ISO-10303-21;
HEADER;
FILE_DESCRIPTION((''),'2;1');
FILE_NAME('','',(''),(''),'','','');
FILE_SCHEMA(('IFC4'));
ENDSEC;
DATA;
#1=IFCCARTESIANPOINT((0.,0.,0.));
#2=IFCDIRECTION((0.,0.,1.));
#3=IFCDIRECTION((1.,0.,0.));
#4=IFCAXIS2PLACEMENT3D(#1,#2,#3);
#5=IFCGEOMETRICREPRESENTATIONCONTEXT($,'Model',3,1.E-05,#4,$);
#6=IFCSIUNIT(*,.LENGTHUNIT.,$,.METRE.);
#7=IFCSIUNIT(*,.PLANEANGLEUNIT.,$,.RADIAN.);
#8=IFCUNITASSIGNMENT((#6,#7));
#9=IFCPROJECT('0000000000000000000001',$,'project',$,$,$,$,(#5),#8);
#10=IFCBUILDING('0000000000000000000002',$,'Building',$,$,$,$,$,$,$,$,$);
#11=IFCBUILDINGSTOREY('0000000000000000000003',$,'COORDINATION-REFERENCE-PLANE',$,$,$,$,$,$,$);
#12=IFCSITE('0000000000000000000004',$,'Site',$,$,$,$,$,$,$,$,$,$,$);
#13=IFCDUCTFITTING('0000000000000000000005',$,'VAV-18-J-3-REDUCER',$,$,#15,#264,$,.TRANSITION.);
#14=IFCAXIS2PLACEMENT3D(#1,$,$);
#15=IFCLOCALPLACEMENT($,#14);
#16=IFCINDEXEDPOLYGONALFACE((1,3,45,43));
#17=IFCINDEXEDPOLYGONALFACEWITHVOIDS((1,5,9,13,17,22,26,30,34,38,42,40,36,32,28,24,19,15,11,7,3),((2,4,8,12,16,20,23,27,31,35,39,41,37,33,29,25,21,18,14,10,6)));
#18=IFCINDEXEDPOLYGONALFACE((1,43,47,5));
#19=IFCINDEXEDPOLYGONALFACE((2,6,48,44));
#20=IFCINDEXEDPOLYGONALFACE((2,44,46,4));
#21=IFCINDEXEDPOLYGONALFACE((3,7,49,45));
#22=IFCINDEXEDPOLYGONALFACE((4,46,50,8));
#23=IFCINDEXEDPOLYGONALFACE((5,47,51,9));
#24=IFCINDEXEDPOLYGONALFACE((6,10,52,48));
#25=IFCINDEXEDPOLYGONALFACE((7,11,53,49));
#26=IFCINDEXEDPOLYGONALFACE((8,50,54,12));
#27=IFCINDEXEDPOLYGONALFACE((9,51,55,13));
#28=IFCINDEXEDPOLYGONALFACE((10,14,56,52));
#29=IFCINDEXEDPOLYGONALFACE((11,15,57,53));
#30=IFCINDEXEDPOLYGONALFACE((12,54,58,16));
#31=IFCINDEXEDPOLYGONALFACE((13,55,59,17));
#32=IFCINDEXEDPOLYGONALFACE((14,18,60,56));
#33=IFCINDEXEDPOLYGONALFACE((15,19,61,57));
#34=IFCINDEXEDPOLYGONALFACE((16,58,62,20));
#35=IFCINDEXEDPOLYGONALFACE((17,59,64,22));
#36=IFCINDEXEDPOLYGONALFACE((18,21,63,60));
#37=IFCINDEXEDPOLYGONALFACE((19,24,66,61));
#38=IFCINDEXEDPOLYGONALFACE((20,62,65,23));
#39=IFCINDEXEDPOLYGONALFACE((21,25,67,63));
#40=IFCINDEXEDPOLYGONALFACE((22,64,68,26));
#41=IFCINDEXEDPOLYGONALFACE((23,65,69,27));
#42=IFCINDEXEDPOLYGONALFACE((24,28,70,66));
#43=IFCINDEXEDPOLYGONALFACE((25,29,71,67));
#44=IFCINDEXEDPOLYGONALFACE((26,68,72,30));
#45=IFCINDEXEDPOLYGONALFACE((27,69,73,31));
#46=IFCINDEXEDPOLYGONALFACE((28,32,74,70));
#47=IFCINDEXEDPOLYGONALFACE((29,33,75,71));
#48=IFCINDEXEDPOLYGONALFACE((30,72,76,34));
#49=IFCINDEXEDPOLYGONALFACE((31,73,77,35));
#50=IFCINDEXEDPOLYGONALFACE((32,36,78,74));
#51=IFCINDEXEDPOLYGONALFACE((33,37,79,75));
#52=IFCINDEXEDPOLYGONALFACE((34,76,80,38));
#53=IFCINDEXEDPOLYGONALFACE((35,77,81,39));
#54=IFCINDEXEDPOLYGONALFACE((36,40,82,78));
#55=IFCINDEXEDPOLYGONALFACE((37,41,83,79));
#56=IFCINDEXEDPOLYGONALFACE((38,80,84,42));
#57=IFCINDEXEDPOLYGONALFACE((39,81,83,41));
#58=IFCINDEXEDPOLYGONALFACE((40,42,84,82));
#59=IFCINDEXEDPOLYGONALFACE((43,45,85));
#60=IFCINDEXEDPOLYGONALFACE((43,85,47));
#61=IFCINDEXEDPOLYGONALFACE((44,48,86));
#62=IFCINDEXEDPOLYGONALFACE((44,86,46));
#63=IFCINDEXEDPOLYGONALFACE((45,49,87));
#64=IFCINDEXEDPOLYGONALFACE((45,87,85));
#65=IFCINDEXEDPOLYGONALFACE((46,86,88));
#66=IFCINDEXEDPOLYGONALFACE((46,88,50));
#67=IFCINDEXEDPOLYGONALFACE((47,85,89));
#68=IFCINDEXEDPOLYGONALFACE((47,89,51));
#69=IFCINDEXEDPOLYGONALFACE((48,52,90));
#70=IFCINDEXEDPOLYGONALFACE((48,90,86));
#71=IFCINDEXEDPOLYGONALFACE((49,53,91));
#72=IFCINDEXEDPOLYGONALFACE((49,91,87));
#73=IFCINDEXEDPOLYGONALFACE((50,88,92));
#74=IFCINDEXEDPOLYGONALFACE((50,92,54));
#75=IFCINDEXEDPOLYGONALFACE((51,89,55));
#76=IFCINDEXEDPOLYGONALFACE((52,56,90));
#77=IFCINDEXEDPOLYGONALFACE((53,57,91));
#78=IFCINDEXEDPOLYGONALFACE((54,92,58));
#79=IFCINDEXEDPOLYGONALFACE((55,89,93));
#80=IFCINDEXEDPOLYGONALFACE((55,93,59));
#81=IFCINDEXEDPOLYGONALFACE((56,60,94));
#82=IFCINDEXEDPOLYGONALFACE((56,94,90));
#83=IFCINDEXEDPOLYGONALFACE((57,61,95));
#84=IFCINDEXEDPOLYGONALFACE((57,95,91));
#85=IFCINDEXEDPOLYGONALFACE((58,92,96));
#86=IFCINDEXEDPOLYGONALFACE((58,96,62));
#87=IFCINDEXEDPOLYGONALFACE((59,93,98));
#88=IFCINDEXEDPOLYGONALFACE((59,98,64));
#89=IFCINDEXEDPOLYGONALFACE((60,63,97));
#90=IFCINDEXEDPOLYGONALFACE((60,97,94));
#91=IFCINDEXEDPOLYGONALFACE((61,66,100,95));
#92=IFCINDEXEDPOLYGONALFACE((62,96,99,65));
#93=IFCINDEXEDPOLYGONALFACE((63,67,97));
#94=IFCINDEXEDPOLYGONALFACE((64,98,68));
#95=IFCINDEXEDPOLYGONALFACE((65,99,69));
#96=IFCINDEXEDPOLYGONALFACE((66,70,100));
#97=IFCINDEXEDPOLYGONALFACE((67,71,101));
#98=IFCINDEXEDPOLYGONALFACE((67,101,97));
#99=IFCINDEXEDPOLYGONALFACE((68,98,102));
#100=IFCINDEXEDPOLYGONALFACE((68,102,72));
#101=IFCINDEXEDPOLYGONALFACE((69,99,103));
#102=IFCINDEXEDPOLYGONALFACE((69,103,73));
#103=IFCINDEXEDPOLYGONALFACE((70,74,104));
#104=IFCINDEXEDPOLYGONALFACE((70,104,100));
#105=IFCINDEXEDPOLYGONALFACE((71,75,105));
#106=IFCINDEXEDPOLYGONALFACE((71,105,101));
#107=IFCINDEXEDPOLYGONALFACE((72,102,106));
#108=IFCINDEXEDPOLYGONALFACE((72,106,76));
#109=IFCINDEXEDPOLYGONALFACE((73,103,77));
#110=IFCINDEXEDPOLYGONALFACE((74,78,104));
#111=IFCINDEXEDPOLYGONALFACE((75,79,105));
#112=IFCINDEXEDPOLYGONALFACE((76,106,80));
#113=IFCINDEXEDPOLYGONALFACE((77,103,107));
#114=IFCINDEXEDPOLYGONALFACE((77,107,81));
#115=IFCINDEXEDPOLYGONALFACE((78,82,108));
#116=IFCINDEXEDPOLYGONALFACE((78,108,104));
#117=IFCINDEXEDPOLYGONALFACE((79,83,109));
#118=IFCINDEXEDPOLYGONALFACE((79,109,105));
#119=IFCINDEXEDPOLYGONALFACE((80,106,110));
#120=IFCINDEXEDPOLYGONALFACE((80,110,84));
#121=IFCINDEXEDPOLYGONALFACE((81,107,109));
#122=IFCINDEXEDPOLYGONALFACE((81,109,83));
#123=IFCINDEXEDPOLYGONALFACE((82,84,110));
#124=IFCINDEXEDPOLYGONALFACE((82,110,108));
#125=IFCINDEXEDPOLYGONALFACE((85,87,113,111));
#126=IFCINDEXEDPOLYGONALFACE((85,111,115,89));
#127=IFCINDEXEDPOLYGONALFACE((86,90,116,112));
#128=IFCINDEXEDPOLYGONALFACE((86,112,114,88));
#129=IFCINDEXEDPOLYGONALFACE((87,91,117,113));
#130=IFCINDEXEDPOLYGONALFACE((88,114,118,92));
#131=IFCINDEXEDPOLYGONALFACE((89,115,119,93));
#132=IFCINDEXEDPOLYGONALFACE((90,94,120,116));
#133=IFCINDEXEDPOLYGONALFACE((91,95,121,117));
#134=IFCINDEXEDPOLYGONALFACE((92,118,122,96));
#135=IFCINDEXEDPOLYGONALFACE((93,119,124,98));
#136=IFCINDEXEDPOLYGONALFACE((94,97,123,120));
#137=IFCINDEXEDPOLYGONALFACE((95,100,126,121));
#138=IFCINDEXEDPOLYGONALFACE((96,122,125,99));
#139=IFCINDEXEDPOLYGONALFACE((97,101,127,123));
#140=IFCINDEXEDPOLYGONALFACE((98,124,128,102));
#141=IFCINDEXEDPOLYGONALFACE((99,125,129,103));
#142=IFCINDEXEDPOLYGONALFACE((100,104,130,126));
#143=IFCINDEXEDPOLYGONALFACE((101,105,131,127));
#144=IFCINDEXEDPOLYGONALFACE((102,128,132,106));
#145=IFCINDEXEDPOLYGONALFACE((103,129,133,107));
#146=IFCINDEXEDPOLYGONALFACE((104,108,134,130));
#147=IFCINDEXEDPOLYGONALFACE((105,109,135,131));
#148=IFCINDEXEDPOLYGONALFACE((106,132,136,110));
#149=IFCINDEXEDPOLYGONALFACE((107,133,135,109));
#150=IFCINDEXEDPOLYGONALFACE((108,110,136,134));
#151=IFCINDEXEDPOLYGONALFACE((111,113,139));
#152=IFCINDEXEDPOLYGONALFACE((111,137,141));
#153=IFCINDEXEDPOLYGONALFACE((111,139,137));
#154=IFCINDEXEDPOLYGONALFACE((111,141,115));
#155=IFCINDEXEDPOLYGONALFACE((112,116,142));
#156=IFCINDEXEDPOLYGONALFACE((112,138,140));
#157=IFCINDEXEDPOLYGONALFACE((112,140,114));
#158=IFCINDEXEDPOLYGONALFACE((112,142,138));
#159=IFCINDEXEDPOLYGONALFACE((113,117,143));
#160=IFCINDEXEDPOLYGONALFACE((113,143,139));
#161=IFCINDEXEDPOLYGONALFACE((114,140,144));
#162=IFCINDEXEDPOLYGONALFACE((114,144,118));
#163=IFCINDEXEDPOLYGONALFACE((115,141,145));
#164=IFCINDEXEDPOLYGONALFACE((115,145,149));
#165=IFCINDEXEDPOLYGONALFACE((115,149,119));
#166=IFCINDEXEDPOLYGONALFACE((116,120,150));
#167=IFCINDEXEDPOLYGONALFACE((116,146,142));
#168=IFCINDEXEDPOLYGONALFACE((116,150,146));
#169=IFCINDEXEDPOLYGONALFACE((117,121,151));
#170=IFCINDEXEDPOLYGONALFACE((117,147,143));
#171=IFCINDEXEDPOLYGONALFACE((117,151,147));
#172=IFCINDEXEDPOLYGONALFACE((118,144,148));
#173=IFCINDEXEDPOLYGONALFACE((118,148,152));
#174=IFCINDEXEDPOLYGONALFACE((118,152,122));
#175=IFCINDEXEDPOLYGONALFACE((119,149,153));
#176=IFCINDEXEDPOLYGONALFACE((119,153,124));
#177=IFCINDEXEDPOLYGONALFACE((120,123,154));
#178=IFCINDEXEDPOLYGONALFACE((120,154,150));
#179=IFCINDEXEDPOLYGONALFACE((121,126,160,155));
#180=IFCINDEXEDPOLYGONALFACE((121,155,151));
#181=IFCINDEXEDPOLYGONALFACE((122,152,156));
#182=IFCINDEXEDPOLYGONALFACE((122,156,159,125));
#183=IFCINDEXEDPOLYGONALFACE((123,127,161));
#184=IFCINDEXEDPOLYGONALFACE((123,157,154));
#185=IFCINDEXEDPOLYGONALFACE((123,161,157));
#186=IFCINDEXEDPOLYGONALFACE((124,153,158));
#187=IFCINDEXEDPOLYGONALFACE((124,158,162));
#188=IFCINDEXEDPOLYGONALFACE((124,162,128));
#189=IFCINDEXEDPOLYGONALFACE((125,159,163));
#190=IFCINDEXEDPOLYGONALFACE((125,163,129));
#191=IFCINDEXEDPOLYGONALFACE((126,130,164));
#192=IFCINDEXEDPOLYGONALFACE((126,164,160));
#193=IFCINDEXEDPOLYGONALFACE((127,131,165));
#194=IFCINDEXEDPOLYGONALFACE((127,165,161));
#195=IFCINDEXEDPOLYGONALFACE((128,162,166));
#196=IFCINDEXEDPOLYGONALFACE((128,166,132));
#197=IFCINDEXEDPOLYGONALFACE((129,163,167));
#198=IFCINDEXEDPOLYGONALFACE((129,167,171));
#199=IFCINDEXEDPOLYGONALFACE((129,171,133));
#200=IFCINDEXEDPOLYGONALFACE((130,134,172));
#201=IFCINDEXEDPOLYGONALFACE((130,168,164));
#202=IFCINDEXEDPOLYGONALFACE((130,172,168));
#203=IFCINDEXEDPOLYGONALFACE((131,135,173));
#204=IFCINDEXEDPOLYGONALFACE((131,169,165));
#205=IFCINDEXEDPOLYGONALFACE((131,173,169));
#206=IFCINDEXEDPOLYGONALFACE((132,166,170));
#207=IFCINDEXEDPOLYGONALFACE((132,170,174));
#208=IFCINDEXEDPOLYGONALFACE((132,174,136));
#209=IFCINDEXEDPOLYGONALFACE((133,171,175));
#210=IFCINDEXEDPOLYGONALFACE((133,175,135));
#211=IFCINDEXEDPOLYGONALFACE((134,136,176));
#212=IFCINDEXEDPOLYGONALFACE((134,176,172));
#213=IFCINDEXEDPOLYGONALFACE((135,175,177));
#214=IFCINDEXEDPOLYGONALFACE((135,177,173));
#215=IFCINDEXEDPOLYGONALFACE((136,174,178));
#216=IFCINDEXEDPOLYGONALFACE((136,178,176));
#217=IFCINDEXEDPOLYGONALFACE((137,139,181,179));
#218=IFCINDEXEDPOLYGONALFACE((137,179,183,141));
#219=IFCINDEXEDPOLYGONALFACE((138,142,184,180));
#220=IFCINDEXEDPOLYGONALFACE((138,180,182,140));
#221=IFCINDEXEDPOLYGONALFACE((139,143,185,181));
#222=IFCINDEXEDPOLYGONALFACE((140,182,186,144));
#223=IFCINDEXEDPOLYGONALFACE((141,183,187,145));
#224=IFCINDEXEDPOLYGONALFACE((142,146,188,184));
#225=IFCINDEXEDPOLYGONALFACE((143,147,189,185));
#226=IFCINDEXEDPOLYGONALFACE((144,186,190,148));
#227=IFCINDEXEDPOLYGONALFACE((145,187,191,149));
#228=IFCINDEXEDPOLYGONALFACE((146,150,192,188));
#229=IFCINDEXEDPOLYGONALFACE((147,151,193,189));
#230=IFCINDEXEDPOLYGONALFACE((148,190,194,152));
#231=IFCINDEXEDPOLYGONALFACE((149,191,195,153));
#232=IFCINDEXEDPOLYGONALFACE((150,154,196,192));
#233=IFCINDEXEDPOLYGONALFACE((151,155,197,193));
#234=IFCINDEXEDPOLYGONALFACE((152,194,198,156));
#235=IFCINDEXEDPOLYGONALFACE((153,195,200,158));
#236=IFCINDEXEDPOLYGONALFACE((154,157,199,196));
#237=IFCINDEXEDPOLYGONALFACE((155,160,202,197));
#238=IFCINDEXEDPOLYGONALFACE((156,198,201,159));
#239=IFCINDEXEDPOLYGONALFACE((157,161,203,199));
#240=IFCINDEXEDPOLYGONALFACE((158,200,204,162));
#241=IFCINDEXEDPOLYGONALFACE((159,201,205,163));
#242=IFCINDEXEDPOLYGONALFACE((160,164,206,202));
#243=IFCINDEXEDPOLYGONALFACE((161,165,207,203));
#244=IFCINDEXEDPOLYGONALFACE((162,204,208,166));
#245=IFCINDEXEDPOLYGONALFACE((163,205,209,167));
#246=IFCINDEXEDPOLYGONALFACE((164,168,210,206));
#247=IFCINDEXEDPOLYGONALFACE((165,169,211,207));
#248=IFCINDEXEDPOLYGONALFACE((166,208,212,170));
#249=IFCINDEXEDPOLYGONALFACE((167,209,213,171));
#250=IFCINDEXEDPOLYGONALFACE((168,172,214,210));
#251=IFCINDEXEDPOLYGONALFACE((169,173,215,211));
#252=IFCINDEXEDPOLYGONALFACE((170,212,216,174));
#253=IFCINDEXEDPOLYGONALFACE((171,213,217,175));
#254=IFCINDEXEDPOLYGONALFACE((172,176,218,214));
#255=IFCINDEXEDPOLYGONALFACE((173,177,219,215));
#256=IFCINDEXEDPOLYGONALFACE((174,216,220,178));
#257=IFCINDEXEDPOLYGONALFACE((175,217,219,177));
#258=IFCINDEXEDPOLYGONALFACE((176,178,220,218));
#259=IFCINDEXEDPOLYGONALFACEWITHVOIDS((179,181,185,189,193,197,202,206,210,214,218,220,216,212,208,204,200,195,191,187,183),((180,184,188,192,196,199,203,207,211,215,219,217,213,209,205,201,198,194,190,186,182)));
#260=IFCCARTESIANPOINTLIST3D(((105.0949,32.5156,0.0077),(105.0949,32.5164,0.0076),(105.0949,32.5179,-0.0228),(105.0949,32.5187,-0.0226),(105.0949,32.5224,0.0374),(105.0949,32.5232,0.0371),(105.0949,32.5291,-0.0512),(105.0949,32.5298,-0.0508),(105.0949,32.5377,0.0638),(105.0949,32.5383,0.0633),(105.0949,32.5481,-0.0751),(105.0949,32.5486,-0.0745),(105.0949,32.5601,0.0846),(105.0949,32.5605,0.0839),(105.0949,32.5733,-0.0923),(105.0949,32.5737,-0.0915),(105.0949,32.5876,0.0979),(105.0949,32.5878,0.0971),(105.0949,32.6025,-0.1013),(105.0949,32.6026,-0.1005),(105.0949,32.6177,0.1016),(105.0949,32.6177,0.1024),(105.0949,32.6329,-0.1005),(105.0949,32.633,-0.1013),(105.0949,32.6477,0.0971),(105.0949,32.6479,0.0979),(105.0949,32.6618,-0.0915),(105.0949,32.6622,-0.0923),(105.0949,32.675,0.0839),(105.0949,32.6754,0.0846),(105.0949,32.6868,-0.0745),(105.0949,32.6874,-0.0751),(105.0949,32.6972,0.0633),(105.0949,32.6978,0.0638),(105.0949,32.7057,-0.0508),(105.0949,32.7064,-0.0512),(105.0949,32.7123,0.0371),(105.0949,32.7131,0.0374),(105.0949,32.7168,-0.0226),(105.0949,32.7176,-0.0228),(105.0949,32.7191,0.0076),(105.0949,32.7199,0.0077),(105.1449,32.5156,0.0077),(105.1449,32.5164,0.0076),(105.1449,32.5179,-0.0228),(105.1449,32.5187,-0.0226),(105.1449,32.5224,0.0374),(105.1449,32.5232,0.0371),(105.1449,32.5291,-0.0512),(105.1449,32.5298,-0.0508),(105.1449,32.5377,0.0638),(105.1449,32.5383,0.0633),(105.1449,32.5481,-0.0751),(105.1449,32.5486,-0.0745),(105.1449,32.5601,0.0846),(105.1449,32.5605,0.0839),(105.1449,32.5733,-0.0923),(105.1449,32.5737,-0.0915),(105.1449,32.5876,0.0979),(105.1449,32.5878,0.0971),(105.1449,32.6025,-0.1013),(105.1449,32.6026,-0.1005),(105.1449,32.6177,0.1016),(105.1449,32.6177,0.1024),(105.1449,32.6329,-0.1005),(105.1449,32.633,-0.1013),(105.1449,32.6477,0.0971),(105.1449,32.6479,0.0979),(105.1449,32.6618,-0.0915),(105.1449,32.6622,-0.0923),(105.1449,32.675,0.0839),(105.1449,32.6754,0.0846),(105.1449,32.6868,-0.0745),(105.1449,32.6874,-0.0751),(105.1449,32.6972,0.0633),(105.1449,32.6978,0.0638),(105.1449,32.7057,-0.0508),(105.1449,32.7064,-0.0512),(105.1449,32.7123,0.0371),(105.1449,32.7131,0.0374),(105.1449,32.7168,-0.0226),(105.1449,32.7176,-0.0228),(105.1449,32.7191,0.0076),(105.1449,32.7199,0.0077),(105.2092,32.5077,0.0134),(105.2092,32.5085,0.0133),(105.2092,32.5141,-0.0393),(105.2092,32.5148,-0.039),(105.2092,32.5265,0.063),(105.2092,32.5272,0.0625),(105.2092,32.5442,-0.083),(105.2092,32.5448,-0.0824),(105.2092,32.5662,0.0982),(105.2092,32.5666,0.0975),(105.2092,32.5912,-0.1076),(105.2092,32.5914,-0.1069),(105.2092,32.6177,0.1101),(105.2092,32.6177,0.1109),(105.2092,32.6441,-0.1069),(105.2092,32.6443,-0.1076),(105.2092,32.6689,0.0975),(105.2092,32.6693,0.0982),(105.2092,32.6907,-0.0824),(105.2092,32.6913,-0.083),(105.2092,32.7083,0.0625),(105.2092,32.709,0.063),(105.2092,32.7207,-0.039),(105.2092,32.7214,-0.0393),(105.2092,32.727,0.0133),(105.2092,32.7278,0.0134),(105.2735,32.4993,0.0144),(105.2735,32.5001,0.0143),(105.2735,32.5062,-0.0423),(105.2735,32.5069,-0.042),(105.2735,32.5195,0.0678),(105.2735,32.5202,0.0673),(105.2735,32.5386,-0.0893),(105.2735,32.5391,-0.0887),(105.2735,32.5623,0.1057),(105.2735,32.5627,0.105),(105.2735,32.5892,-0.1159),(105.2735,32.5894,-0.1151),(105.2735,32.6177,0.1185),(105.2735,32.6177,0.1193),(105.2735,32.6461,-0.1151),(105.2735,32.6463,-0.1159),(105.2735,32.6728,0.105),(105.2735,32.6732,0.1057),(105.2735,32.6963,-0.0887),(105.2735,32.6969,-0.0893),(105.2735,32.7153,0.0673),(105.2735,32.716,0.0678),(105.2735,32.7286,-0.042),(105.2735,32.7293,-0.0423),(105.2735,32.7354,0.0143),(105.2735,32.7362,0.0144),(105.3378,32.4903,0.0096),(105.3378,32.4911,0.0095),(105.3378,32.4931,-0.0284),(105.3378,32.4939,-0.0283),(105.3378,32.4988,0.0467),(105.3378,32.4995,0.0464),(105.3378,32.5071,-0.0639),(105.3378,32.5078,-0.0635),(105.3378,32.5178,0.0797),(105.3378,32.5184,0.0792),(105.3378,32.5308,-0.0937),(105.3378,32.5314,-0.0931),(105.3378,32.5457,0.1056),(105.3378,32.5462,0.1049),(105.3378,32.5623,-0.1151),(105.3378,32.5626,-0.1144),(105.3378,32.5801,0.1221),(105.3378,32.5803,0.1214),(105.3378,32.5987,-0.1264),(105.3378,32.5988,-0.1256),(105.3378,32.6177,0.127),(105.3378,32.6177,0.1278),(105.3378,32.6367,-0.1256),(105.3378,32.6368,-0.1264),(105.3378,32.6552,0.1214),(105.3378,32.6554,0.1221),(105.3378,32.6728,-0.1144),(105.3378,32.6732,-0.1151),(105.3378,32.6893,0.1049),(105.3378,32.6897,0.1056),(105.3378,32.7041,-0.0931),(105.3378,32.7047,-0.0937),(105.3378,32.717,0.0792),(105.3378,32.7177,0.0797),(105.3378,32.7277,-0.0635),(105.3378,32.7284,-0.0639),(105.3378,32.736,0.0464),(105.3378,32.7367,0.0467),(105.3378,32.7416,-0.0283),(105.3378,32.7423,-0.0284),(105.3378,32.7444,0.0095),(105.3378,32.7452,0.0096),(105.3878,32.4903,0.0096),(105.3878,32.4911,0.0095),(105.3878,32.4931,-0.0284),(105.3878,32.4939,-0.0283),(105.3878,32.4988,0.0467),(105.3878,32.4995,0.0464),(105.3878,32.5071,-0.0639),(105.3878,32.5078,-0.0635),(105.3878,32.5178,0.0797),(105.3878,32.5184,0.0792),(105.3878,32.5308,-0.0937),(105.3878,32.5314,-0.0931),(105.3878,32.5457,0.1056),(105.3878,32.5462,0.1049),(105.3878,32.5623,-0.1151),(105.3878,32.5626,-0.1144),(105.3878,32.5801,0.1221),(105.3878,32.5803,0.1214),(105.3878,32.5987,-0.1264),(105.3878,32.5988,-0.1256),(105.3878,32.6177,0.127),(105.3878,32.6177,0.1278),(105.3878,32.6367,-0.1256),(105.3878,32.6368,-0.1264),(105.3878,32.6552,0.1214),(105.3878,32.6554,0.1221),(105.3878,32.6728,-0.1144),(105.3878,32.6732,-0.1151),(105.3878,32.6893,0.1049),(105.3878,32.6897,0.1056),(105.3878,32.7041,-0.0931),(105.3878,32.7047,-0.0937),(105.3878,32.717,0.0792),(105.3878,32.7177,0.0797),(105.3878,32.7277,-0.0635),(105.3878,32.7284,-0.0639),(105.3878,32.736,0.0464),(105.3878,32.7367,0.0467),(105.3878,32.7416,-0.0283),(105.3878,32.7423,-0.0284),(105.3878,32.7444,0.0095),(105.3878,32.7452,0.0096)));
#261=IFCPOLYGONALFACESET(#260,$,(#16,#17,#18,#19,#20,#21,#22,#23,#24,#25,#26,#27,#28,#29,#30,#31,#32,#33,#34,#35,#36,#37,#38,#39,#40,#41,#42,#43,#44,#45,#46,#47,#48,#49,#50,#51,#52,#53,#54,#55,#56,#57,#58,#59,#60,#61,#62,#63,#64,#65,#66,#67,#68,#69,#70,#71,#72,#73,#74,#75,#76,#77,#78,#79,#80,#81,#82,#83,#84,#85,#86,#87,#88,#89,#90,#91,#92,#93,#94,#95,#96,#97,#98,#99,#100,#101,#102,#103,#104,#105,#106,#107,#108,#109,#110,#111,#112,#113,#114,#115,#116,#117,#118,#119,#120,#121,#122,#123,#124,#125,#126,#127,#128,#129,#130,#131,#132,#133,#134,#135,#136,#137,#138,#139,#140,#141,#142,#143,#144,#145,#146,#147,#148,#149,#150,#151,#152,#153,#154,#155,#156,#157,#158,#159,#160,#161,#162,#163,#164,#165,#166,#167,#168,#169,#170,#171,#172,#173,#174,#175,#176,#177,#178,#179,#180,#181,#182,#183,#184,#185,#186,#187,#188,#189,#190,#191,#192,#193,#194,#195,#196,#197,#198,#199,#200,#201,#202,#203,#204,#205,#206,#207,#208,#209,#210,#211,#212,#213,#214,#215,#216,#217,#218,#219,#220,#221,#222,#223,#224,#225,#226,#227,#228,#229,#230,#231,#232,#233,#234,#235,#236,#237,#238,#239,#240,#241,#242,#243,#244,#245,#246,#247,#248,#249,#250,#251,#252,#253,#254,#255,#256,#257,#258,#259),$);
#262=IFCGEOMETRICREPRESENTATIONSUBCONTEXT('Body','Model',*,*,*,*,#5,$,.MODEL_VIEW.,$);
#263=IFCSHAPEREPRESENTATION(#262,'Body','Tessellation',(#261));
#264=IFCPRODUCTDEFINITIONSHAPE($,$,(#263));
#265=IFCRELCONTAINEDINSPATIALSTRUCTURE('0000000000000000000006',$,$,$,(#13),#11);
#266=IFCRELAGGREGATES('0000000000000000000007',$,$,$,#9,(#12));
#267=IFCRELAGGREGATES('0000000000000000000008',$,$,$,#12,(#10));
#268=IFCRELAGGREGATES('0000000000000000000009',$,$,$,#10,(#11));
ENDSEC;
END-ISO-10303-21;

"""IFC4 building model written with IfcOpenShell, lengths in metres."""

from ifc_helpers import new_model, entity, si_unit, frame, origin_with_axes, place, context, subcontext, project, spatial, element, save


model = new_model("IFC4")

# Units and contexts
model_context = context("Model", 3, precision=1e-05, world=origin_with_axes())
body_context_1 = subcontext(model_context, "Body", "Model", "MODEL_VIEW")
ifc_project = project(units=[si_unit("LENGTHUNIT", "METRE"), si_unit("PLANEANGLEUNIT", "RADIAN")], contexts=[model_context])

# Site, building, storey
site = spatial("IfcSite", under=ifc_project, Name="Site")
building = spatial("IfcBuilding", under=site, Name="Building")
storey = spatial("IfcBuildingStorey", under=building, Name="COORDINATION-REFERENCE-PLANE")

# Duct fitting
for number, where, z_axis, x_axis, name in (
    (1, (105.3878, 32.6177, 0.0), (0.0, -1.0, 0.0), (0.0, 0.0, 1.0), "VAV-18-J-3-REDUCER"),
):
    element("IfcDuctFitting", number, at=place(None, frame(where, z_axis=z_axis, x_axis=x_axis)), inside=storey, Name=name, PredefinedType="TRANSITION", context=body_context_1, shape_type="SweptSolid", body=[
        entity("IfcRevolvedAreaSolid", entity("IfcArbitraryClosedProfileDef", "AREA", None, entity("IfcPolyline", [entity("IfcCartesianPoint", [0.1278, 0.0]), entity("IfcCartesianPoint", [0.1278, 0.05]), entity("IfcCartesianPoint", [0.1024, 0.2429]), entity("IfcCartesianPoint", [0.1024, 0.2929]), entity("IfcCartesianPoint", [0.1016, 0.2929]), entity("IfcCartesianPoint", [0.1016, 0.2429]), entity("IfcCartesianPoint", [0.127, 0.05]), entity("IfcCartesianPoint", [0.127, 0.0]), entity("IfcCartesianPoint", [0.1278, 0.0])])), entity("IfcAxis2Placement3D", entity("IfcCartesianPoint", [0.0, 0.0, 0.0])), entity("IfcAxis1Placement", entity("IfcCartesianPoint", [0.0, 0.0, 0.0]), entity("IfcDirection", [0.0, 1.0, 0.0])), 6.283185),
    ])

save(model, "model.ifc")
